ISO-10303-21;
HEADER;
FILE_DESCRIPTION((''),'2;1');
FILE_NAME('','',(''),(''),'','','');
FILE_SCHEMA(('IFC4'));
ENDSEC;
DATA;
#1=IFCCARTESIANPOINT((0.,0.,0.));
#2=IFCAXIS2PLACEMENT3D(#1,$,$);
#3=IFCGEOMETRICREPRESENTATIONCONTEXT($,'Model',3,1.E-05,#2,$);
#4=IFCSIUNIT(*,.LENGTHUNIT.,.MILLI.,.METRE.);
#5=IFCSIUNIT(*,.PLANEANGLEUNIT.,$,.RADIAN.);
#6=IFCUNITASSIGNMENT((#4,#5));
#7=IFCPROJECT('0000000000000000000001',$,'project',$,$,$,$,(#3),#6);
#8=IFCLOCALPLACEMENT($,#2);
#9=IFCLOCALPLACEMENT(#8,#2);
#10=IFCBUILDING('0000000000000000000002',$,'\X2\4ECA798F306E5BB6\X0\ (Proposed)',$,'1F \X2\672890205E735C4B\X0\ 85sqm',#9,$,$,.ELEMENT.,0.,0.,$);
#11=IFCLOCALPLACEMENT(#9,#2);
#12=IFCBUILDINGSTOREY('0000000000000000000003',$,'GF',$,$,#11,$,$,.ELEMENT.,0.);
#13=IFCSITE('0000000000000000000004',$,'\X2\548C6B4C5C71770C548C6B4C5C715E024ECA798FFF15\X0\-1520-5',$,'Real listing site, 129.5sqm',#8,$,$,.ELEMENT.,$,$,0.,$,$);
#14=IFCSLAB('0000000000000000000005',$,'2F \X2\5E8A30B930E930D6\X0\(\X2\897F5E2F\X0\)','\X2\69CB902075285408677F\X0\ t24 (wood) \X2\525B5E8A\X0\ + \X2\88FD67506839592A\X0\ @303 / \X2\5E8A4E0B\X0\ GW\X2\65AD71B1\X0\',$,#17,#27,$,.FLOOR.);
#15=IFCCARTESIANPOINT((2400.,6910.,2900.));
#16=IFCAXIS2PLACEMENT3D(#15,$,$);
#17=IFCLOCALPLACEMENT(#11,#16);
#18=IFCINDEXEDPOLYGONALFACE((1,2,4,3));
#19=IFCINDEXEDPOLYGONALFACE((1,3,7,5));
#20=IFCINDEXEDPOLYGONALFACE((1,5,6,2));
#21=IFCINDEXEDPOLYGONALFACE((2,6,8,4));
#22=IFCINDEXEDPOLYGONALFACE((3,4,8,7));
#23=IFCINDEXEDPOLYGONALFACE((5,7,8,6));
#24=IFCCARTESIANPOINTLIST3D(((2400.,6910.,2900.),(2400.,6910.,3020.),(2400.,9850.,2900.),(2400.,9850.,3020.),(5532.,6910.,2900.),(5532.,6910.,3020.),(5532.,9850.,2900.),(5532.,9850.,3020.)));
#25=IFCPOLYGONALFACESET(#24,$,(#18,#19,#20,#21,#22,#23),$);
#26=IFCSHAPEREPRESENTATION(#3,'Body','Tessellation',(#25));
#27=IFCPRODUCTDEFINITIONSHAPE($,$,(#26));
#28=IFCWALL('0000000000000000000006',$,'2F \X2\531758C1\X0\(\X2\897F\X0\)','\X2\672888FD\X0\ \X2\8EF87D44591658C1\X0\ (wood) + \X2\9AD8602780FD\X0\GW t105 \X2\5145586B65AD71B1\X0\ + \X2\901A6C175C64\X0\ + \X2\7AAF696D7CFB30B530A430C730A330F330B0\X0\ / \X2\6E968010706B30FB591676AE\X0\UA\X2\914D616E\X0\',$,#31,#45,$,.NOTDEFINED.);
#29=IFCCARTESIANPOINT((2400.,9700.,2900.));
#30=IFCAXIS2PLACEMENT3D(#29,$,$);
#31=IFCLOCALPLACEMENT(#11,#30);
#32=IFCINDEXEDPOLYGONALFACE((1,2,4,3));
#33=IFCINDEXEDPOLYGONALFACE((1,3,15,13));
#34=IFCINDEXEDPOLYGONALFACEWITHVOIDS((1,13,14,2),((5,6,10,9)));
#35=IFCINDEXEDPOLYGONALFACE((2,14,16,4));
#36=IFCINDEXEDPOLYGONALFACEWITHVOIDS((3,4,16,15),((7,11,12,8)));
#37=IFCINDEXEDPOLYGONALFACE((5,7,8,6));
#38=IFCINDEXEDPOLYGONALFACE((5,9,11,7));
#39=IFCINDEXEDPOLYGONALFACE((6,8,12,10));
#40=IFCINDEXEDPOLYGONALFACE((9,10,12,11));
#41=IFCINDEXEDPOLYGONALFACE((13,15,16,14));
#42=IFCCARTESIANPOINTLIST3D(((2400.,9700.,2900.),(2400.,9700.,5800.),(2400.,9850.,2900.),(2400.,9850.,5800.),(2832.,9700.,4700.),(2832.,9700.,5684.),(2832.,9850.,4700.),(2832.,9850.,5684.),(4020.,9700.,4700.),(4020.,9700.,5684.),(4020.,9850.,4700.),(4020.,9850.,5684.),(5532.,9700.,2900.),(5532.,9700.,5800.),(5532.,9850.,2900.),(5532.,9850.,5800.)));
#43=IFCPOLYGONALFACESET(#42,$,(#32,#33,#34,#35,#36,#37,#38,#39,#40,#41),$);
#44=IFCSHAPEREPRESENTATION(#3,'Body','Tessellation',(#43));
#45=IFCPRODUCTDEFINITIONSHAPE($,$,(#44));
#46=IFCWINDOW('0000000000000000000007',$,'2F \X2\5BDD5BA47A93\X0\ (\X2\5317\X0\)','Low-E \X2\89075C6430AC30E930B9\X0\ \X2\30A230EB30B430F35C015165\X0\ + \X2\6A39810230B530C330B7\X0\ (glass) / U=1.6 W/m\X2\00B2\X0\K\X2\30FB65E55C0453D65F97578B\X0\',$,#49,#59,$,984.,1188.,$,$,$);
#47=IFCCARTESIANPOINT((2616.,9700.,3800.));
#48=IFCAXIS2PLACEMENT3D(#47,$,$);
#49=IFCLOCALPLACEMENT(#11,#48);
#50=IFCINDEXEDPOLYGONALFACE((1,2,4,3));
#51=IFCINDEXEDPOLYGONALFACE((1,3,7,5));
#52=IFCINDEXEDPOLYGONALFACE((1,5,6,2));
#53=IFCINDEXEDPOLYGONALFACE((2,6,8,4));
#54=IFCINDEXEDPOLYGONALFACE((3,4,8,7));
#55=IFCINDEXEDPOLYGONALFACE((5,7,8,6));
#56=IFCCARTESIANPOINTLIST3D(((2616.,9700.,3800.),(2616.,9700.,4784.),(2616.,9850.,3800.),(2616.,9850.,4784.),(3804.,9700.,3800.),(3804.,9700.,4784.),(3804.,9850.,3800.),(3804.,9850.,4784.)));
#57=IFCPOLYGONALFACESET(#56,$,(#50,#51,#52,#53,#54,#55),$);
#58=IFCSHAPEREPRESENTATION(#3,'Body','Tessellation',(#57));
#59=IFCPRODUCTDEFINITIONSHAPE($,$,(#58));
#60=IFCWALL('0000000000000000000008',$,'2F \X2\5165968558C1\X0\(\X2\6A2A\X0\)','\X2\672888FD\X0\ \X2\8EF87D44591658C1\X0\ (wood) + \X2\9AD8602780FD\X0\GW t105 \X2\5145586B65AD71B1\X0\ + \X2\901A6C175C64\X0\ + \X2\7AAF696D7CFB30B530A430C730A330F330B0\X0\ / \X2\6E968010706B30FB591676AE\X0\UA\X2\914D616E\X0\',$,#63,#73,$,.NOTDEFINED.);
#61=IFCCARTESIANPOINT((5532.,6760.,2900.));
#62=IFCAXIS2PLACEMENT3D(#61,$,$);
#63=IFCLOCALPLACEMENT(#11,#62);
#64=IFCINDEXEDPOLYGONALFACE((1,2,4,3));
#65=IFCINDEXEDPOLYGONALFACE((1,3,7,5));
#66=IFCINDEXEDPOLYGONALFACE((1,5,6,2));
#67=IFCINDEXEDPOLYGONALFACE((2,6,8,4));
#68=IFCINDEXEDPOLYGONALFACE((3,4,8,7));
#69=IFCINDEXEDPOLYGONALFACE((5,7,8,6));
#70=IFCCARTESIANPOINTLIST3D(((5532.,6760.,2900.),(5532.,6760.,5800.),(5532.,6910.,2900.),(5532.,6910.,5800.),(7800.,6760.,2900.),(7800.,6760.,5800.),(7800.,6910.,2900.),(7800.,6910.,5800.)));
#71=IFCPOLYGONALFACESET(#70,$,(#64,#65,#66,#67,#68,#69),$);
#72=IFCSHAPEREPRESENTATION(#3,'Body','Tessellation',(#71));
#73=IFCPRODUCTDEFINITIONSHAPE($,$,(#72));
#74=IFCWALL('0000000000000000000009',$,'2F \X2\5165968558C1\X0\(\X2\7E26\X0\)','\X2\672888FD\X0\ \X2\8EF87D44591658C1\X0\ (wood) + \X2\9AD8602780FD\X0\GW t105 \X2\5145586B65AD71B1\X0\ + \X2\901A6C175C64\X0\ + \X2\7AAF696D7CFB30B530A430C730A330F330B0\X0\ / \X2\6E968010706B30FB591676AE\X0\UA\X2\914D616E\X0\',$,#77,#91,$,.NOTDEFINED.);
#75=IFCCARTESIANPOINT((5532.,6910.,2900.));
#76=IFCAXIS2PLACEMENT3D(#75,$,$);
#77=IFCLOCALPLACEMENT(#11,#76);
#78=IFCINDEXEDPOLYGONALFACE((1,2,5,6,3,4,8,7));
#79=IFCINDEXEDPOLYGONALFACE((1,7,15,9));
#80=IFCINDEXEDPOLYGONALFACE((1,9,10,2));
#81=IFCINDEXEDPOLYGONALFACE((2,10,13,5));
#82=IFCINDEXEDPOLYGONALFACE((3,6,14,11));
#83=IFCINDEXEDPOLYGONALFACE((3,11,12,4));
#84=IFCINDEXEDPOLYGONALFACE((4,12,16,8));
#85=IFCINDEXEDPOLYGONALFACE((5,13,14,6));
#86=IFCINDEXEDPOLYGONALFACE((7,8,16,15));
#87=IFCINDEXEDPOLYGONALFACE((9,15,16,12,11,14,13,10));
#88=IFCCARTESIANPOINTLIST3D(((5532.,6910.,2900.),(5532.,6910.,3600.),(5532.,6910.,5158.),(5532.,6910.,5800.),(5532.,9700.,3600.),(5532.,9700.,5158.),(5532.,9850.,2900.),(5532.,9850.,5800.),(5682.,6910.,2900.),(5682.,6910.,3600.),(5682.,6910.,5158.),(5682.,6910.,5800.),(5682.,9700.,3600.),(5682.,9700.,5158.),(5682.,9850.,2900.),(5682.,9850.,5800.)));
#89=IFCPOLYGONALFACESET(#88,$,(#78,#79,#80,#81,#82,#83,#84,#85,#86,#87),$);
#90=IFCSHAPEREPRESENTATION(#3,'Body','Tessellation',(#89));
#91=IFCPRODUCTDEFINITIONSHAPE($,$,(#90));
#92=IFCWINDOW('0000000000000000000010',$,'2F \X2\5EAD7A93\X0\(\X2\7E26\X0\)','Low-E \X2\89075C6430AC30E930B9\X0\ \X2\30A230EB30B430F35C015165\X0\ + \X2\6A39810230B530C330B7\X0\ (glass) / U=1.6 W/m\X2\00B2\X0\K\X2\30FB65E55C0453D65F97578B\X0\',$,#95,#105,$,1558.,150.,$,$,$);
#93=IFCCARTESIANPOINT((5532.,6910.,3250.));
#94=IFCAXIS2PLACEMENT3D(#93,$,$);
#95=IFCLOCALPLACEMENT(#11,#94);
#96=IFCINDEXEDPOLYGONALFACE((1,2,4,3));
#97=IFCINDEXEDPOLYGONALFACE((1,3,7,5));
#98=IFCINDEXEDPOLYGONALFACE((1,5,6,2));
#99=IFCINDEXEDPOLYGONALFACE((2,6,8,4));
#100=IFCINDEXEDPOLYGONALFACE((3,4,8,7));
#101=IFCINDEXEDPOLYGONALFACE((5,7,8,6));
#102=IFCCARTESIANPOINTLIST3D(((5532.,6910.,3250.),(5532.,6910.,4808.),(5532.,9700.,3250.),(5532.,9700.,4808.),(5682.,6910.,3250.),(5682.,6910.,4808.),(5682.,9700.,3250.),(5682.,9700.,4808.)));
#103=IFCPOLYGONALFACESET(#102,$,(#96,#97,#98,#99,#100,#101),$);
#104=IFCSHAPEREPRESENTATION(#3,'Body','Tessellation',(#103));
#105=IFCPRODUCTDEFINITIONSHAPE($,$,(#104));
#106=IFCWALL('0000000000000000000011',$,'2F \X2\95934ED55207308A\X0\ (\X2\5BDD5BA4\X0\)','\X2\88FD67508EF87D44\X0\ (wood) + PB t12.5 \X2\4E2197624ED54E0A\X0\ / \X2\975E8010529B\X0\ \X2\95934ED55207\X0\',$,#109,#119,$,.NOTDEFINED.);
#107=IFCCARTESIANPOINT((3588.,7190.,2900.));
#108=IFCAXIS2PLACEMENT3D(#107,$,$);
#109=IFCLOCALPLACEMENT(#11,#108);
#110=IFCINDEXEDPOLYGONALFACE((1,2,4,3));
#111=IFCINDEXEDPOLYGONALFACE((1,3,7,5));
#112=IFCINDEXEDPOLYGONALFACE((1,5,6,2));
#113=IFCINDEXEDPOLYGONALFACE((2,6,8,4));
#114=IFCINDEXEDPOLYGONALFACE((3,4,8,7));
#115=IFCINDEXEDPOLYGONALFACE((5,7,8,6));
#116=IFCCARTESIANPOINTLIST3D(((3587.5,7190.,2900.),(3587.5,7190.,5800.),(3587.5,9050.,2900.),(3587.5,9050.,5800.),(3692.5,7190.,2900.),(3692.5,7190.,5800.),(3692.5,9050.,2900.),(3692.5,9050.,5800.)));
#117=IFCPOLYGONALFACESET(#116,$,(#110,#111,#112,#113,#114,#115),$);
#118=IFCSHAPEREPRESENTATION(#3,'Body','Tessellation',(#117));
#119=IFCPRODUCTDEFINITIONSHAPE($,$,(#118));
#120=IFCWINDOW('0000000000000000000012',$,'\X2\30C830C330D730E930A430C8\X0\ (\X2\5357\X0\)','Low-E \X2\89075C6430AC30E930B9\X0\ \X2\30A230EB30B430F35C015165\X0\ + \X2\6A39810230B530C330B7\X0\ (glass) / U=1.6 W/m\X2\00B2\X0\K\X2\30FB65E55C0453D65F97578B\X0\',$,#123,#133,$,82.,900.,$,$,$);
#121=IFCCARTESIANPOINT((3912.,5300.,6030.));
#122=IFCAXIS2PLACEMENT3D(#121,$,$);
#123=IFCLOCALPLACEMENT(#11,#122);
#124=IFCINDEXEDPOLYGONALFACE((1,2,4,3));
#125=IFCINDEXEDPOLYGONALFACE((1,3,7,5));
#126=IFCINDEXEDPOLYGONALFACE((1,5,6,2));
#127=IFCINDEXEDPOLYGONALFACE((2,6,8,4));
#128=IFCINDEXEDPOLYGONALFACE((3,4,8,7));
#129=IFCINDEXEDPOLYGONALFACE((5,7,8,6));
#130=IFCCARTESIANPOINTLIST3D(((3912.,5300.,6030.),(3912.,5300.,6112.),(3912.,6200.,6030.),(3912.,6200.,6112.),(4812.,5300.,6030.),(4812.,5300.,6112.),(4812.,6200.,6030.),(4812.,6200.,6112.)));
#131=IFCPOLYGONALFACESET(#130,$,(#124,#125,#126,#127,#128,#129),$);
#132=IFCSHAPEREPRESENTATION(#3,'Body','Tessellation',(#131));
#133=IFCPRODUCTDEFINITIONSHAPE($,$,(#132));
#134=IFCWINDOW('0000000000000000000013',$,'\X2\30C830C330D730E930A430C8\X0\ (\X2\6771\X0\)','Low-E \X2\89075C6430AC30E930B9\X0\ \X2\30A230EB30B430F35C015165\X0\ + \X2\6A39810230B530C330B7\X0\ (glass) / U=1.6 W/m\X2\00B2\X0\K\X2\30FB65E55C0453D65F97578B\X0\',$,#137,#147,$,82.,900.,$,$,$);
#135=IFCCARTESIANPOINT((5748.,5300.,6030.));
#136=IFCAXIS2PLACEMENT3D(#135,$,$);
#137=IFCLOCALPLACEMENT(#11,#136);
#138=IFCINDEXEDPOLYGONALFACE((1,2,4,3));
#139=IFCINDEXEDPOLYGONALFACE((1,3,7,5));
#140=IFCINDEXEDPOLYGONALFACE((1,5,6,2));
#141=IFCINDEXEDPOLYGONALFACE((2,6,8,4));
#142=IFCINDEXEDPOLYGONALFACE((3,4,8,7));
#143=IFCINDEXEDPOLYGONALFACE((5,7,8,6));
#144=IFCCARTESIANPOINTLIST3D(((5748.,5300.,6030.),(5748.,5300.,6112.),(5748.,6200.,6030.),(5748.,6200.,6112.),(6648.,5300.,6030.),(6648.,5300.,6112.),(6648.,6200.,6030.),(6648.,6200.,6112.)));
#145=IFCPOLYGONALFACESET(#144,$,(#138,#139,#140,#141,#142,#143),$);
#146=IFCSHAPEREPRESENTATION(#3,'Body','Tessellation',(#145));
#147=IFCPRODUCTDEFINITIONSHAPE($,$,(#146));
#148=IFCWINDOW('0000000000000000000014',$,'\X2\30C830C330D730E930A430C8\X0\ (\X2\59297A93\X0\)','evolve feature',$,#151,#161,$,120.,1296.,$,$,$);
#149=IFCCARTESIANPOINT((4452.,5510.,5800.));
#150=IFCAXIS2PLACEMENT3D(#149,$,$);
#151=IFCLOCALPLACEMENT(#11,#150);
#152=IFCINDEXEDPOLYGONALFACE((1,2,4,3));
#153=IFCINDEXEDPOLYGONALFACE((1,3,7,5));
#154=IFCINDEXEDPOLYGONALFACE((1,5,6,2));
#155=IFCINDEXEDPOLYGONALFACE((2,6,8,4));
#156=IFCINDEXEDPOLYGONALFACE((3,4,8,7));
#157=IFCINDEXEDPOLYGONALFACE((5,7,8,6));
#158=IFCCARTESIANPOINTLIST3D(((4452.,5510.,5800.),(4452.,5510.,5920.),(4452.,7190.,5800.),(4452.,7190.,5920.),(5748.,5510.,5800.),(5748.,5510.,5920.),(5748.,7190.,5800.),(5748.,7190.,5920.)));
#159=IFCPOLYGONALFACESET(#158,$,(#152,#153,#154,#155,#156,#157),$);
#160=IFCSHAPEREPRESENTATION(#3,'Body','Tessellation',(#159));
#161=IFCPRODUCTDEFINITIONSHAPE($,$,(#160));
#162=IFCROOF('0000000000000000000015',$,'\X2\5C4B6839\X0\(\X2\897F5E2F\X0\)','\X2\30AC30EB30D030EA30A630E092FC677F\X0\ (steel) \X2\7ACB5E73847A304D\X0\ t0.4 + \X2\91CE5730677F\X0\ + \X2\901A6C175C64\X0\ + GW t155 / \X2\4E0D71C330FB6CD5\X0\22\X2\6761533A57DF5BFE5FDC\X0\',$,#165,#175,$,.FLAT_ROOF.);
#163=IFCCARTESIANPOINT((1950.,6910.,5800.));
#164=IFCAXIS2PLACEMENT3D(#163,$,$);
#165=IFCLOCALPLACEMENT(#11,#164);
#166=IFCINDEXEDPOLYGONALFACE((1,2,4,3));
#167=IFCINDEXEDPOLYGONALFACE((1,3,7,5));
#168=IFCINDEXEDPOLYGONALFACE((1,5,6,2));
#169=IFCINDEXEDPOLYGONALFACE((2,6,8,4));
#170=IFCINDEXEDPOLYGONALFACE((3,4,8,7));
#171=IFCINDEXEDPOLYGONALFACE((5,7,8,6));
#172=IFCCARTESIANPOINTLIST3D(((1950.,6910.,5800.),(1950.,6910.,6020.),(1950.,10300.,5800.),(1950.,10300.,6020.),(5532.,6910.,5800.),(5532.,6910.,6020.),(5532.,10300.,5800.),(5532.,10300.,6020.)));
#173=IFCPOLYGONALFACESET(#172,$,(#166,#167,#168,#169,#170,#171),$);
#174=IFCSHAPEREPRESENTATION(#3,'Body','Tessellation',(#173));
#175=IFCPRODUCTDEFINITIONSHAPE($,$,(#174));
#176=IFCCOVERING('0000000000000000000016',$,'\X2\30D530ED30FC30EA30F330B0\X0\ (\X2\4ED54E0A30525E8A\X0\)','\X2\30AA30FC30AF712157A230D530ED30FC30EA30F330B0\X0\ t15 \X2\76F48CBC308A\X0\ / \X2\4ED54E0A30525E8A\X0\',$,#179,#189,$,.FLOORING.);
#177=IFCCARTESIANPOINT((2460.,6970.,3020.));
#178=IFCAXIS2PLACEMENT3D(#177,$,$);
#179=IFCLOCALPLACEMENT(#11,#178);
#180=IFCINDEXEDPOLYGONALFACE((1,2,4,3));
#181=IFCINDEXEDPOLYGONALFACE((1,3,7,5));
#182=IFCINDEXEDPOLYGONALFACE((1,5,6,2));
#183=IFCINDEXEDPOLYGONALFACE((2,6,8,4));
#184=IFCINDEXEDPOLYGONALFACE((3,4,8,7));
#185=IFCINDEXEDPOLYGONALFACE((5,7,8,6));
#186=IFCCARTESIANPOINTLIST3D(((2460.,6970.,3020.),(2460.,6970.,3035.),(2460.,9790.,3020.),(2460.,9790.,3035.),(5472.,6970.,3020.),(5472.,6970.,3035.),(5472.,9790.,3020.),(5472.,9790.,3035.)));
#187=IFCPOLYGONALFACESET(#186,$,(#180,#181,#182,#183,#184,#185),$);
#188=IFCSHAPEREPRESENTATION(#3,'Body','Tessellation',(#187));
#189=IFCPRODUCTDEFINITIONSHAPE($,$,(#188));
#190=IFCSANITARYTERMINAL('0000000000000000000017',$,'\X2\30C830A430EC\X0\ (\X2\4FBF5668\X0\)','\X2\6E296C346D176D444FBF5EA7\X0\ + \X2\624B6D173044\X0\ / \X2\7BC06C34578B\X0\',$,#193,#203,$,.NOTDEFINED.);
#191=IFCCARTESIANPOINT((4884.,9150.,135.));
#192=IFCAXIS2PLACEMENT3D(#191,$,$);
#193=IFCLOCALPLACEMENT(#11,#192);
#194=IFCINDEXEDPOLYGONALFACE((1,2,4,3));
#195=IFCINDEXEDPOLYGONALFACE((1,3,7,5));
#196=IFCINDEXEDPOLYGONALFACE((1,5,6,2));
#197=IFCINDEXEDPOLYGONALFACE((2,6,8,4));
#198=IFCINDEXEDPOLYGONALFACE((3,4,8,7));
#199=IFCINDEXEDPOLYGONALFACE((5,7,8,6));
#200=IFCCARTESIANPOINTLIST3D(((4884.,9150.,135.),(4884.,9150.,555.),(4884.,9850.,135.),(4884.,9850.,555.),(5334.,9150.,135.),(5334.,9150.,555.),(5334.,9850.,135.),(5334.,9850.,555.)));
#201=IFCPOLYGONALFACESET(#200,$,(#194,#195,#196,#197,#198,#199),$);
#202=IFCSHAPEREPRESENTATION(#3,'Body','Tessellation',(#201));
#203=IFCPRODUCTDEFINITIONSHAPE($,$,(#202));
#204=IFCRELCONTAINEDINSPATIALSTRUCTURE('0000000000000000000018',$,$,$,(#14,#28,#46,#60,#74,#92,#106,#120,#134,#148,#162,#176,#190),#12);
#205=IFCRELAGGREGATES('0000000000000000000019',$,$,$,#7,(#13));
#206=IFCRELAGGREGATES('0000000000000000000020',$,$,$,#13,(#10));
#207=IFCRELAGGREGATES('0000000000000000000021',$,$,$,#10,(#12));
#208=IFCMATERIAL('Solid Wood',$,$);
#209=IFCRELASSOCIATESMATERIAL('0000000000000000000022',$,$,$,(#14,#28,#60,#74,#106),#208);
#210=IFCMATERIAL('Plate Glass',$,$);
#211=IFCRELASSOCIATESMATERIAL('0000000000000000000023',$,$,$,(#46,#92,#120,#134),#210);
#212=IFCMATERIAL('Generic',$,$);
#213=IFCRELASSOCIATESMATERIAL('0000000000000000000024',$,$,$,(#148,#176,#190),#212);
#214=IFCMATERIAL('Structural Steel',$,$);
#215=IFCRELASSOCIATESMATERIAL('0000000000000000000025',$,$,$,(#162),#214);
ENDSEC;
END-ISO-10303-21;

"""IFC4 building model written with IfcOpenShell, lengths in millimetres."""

from ifc_helpers import new_model, si_unit, frame, frame_2d, origin, place, context, project, spatial, rectangle, extrude, material, element, fill, save


model = new_model("IFC4")

# Units and contexts
model_context = context("Model", 3, precision=1e-05, world=origin())
ifc_project = project(units=[si_unit("LENGTHUNIT", "METRE", prefix="MILLI"), si_unit("PLANEANGLEUNIT", "RADIAN")], contexts=[model_context])

# Site, building, storey
site_placement = place(None, origin())
site = spatial("IfcSite", under=ifc_project, at=site_placement, Name="和歌山県和歌山市今福５-1520-5", ObjectType="Real listing site, 129.5sqm", CompositionType="ELEMENT", RefElevation=0.0)
building_placement = place(site_placement, origin())
building = spatial("IfcBuilding", under=site, at=building_placement, Name="今福の家 (Proposed)", ObjectType="1F 木造平屋 85sqm", CompositionType="ELEMENT", ElevationOfRefHeight=0.0, ElevationOfTerrain=0.0)
storey_placement = place(building_placement, origin())
storey = spatial("IfcBuildingStorey", under=building, at=storey_placement, Name="GF", CompositionType="ELEMENT", Elevation=0.0)

# Slab
ifc_material_1 = material(Name="Solid Wood")
slab_placement = place(storey_placement, frame((2400.0, 6910.0, 2900.0)))
element("IfcSlab", 1, at=slab_placement, inside=storey, material=ifc_material_1, Name="2F 床スラブ(西帯)", Description="構造用合板 t24 (wood) 剛床 + 製材根太 @303 / 床下 GW断熱", PredefinedType="FLOOR", context=model_context, shape_type="SweptSolid", body=[
    extrude(rectangle(XDim=3132.0, YDim=2940.0, at=frame_2d((1566.0, 1470.0))), frame((2400.0, 6910.0, 2900.0)), (0.0, 0.0, 1.0), 120.0),
])

# Wall, opening, window
wall_1_placement = place(storey_placement, frame((2400.0, 9700.0, 2900.0)))
wall_1 = element("IfcWall", 2, at=wall_1_placement, inside=storey, material=ifc_material_1, Name="2F 北壁(西)", Description="木製 軸組外壁 (wood) + 高性能GW t105 充填断熱 + 通気層 + 窯業系サイディング / 準耐火・外皮UA配慮", PredefinedType="NOTDEFINED", context=model_context, shape_type="SweptSolid", body=[
    extrude(rectangle(XDim=3132.0, YDim=150.0, at=frame_2d((1566.0, 75.0))), frame((2400.0, 9700.0, 2900.0)), (0.0, 0.0, 1.0), 2900.0),
])
opening_1_placement = place(storey_placement, frame((2616.0, 9700.0, 3800.0)))
opening_1 = element("IfcOpeningElement", 3, at=opening_1_placement, cuts=wall_1, PredefinedType="NOTDEFINED", context=model_context, shape_type="SweptSolid", body=[
    extrude(rectangle(XDim=1188.0, YDim=150.0, at=frame_2d((594.0, 75.0))), frame((2616.0, 9700.0, 3800.0)), (0.0, 0.0, 1.0), 984.0),
])
ifc_material_2 = material(Name="Plate Glass")
window_1_placement = place(storey_placement, frame((2616.0, 9700.0, 3800.0)))
window_1 = element("IfcWindow", 4, at=window_1_placement, inside=storey, material=ifc_material_2, Name="2F 寝室窓 (北)", Description="Low-E 複層ガラス アルゴン封入 + 樹脂サッシ (glass) / U=1.6 W/m²K・日射取得型", OverallHeight=984.0, OverallWidth=1188.0, context=model_context, shape_type="SweptSolid", body=[
    extrude(rectangle(XDim=1188.0, YDim=150.0, at=frame_2d((594.0, 75.0))), frame((2616.0, 9700.0, 3800.0)), (0.0, 0.0, 1.0), 984.0),
])
fill(opening_1, window_1)

# Wall
wall_2_placement = place(storey_placement, frame((5532.0, 6760.0, 2900.0)))
element("IfcWall", 5, at=wall_2_placement, inside=storey, material=ifc_material_1, Name="2F 入隅壁(横)", Description="木製 軸組外壁 (wood) + 高性能GW t105 充填断熱 + 通気層 + 窯業系サイディング / 準耐火・外皮UA配慮", PredefinedType="NOTDEFINED", context=model_context, shape_type="SweptSolid", body=[
    extrude(rectangle(XDim=2268.0, YDim=150.0, at=frame_2d((1134.0, 75.0))), frame((5532.0, 6760.0, 2900.0)), (0.0, 0.0, 1.0), 2900.0),
])

# Wall, opening, window
wall_3_placement = place(storey_placement, frame((5532.0, 6910.0, 2900.0)))
wall_3 = element("IfcWall", 6, at=wall_3_placement, inside=storey, material=ifc_material_1, Name="2F 入隅壁(縦)", Description="木製 軸組外壁 (wood) + 高性能GW t105 充填断熱 + 通気層 + 窯業系サイディング / 準耐火・外皮UA配慮", PredefinedType="NOTDEFINED", context=model_context, shape_type="SweptSolid", body=[
    extrude(rectangle(XDim=150.0, YDim=2940.0, at=frame_2d((75.0, 1470.0))), frame((5532.0, 6910.0, 2900.0)), (0.0, 0.0, 1.0), 2900.0),
])
opening_2_placement = place(storey_placement, frame((5532.0, 6910.0, 3250.0)))
opening_2 = element("IfcOpeningElement", 7, at=opening_2_placement, cuts=wall_3, PredefinedType="NOTDEFINED", context=model_context, shape_type="SweptSolid", body=[
    extrude(rectangle(XDim=150.0, YDim=2790.0, at=frame_2d((75.0, 1395.0))), frame((5532.0, 6910.0, 3250.0)), (0.0, 0.0, 1.0), 1558.0),
])
window_2_placement = place(storey_placement, frame((5532.0, 6910.0, 3250.0)))
window_2 = element("IfcWindow", 8, at=window_2_placement, inside=storey, material=ifc_material_2, Name="2F 庭窓(縦)", Description="Low-E 複層ガラス アルゴン封入 + 樹脂サッシ (glass) / U=1.6 W/m²K・日射取得型", OverallHeight=1558.0, OverallWidth=150.0, context=model_context, shape_type="SweptSolid", body=[
    extrude(rectangle(XDim=150.0, YDim=2790.0, at=frame_2d((75.0, 1395.0))), frame((5532.0, 6910.0, 3250.0)), (0.0, 0.0, 1.0), 1558.0),
])
fill(opening_2, window_2)

# Wall
wall_4_placement = place(storey_placement, frame((3588.0, 7190.0, 2900.0)))
element("IfcWall", 9, at=wall_4_placement, inside=storey, material=ifc_material_1, Name="2F 間仕切り (寝室)", Description="製材軸組 (wood) + PB t12.5 両面仕上 / 非耐力 間仕切", PredefinedType="NOTDEFINED", context=model_context, shape_type="SweptSolid", body=[
    extrude(rectangle(XDim=105.0, YDim=1860.0, at=frame_2d((52.0, 930.0))), frame((3588.0, 7190.0, 2900.0)), (0.0, 0.0, 1.0), 2900.0),
])

# Windows
window_3_placement = place(storey_placement, frame((3912.0, 5300.0, 6030.0)))
element("IfcWindow", 10, at=window_3_placement, inside=storey, material=ifc_material_2, Name="トップライト (南)", Description="Low-E 複層ガラス アルゴン封入 + 樹脂サッシ (glass) / U=1.6 W/m²K・日射取得型", OverallHeight=82.0, OverallWidth=900.0, context=model_context, shape_type="SweptSolid", body=[
    extrude(rectangle(XDim=900.0, YDim=900.0, at=frame_2d((450.0, 450.0))), frame((3912.0, 5300.0, 6030.0)), (0.0, 0.0, 1.0), 82.0),
])
window_4_placement = place(storey_placement, frame((5748.0, 5300.0, 6030.0)))
element("IfcWindow", 11, at=window_4_placement, inside=storey, material=ifc_material_2, Name="トップライト (東)", Description="Low-E 複層ガラス アルゴン封入 + 樹脂サッシ (glass) / U=1.6 W/m²K・日射取得型", OverallHeight=82.0, OverallWidth=900.0, context=model_context, shape_type="SweptSolid", body=[
    extrude(rectangle(XDim=900.0, YDim=900.0, at=frame_2d((450.0, 450.0))), frame((5748.0, 5300.0, 6030.0)), (0.0, 0.0, 1.0), 82.0),
])
ifc_material_3 = material(Name="Generic")
window_5_placement = place(storey_placement, frame((4452.0, 5510.0, 5800.0)))
element("IfcWindow", 12, at=window_5_placement, inside=storey, material=ifc_material_3, Name="トップライト (天窓)", Description="evolve feature", OverallHeight=120.0, OverallWidth=1296.0, context=model_context, shape_type="SweptSolid", body=[
    extrude(rectangle(XDim=1296.0, YDim=1680.0, at=frame_2d((648.0, 840.0))), frame((4452.0, 5510.0, 5800.0)), (0.0, 0.0, 1.0), 120.0),
])

# Roof
ifc_material_4 = material(Name="Structural Steel")
for number, where, name in (
    (13, (1950.0, 6910.0, 5800.0), "屋根(西帯)"),
):
    element("IfcRoof", number, at=place(storey_placement, frame(where)), inside=storey, material=ifc_material_4, Name=name, Description="ガルバリウム鋼板 (steel) 立平葺き t0.4 + 野地板 + 通気層 + GW t155 / 不燃・法22条区域対応", PredefinedType="FLAT_ROOF", context=model_context, shape_type="SweptSolid", body=[
        extrude(rectangle(XDim=3582.0, YDim=3390.0, at=frame_2d((1791.0, 1695.0))), frame((1950.0, 6910.0, 5800.0)), (0.0, 0.0, 1.0), 220.0),
    ])

# Covering
covering_placement = place(storey_placement, frame((2460.0, 6970.0, 3020.0)))
element("IfcCovering", 14, at=covering_placement, inside=storey, material=ifc_material_3, Name="フローリング (仕上げ床)", Description="オーク無垢フローリング t15 直貼り / 仕上げ床", PredefinedType="FLOORING", context=model_context, shape_type="SweptSolid", body=[
    extrude(rectangle(XDim=3012.0, YDim=2820.0, at=frame_2d((1506.0, 1410.0))), frame((2460.0, 6970.0, 3020.0)), (0.0, 0.0, 1.0), 15.0),
])

# Sanitary terminal
sanitary_terminal_placement = place(storey_placement, frame((4884.0, 9150.0, 135.0)))
element("IfcSanitaryTerminal", 15, at=sanitary_terminal_placement, inside=storey, material=ifc_material_3, Name="トイレ (便器)", Description="温水洗浄便座 + 手洗い / 節水型", PredefinedType="NOTDEFINED", context=model_context, shape_type="SweptSolid", body=[
    extrude(rectangle(XDim=450.0, YDim=700.0, at=frame_2d((225.0, 350.0))), frame((4884.0, 9150.0, 135.0)), (0.0, 0.0, 1.0), 420.0),
])

save(model, "model.ifc")
